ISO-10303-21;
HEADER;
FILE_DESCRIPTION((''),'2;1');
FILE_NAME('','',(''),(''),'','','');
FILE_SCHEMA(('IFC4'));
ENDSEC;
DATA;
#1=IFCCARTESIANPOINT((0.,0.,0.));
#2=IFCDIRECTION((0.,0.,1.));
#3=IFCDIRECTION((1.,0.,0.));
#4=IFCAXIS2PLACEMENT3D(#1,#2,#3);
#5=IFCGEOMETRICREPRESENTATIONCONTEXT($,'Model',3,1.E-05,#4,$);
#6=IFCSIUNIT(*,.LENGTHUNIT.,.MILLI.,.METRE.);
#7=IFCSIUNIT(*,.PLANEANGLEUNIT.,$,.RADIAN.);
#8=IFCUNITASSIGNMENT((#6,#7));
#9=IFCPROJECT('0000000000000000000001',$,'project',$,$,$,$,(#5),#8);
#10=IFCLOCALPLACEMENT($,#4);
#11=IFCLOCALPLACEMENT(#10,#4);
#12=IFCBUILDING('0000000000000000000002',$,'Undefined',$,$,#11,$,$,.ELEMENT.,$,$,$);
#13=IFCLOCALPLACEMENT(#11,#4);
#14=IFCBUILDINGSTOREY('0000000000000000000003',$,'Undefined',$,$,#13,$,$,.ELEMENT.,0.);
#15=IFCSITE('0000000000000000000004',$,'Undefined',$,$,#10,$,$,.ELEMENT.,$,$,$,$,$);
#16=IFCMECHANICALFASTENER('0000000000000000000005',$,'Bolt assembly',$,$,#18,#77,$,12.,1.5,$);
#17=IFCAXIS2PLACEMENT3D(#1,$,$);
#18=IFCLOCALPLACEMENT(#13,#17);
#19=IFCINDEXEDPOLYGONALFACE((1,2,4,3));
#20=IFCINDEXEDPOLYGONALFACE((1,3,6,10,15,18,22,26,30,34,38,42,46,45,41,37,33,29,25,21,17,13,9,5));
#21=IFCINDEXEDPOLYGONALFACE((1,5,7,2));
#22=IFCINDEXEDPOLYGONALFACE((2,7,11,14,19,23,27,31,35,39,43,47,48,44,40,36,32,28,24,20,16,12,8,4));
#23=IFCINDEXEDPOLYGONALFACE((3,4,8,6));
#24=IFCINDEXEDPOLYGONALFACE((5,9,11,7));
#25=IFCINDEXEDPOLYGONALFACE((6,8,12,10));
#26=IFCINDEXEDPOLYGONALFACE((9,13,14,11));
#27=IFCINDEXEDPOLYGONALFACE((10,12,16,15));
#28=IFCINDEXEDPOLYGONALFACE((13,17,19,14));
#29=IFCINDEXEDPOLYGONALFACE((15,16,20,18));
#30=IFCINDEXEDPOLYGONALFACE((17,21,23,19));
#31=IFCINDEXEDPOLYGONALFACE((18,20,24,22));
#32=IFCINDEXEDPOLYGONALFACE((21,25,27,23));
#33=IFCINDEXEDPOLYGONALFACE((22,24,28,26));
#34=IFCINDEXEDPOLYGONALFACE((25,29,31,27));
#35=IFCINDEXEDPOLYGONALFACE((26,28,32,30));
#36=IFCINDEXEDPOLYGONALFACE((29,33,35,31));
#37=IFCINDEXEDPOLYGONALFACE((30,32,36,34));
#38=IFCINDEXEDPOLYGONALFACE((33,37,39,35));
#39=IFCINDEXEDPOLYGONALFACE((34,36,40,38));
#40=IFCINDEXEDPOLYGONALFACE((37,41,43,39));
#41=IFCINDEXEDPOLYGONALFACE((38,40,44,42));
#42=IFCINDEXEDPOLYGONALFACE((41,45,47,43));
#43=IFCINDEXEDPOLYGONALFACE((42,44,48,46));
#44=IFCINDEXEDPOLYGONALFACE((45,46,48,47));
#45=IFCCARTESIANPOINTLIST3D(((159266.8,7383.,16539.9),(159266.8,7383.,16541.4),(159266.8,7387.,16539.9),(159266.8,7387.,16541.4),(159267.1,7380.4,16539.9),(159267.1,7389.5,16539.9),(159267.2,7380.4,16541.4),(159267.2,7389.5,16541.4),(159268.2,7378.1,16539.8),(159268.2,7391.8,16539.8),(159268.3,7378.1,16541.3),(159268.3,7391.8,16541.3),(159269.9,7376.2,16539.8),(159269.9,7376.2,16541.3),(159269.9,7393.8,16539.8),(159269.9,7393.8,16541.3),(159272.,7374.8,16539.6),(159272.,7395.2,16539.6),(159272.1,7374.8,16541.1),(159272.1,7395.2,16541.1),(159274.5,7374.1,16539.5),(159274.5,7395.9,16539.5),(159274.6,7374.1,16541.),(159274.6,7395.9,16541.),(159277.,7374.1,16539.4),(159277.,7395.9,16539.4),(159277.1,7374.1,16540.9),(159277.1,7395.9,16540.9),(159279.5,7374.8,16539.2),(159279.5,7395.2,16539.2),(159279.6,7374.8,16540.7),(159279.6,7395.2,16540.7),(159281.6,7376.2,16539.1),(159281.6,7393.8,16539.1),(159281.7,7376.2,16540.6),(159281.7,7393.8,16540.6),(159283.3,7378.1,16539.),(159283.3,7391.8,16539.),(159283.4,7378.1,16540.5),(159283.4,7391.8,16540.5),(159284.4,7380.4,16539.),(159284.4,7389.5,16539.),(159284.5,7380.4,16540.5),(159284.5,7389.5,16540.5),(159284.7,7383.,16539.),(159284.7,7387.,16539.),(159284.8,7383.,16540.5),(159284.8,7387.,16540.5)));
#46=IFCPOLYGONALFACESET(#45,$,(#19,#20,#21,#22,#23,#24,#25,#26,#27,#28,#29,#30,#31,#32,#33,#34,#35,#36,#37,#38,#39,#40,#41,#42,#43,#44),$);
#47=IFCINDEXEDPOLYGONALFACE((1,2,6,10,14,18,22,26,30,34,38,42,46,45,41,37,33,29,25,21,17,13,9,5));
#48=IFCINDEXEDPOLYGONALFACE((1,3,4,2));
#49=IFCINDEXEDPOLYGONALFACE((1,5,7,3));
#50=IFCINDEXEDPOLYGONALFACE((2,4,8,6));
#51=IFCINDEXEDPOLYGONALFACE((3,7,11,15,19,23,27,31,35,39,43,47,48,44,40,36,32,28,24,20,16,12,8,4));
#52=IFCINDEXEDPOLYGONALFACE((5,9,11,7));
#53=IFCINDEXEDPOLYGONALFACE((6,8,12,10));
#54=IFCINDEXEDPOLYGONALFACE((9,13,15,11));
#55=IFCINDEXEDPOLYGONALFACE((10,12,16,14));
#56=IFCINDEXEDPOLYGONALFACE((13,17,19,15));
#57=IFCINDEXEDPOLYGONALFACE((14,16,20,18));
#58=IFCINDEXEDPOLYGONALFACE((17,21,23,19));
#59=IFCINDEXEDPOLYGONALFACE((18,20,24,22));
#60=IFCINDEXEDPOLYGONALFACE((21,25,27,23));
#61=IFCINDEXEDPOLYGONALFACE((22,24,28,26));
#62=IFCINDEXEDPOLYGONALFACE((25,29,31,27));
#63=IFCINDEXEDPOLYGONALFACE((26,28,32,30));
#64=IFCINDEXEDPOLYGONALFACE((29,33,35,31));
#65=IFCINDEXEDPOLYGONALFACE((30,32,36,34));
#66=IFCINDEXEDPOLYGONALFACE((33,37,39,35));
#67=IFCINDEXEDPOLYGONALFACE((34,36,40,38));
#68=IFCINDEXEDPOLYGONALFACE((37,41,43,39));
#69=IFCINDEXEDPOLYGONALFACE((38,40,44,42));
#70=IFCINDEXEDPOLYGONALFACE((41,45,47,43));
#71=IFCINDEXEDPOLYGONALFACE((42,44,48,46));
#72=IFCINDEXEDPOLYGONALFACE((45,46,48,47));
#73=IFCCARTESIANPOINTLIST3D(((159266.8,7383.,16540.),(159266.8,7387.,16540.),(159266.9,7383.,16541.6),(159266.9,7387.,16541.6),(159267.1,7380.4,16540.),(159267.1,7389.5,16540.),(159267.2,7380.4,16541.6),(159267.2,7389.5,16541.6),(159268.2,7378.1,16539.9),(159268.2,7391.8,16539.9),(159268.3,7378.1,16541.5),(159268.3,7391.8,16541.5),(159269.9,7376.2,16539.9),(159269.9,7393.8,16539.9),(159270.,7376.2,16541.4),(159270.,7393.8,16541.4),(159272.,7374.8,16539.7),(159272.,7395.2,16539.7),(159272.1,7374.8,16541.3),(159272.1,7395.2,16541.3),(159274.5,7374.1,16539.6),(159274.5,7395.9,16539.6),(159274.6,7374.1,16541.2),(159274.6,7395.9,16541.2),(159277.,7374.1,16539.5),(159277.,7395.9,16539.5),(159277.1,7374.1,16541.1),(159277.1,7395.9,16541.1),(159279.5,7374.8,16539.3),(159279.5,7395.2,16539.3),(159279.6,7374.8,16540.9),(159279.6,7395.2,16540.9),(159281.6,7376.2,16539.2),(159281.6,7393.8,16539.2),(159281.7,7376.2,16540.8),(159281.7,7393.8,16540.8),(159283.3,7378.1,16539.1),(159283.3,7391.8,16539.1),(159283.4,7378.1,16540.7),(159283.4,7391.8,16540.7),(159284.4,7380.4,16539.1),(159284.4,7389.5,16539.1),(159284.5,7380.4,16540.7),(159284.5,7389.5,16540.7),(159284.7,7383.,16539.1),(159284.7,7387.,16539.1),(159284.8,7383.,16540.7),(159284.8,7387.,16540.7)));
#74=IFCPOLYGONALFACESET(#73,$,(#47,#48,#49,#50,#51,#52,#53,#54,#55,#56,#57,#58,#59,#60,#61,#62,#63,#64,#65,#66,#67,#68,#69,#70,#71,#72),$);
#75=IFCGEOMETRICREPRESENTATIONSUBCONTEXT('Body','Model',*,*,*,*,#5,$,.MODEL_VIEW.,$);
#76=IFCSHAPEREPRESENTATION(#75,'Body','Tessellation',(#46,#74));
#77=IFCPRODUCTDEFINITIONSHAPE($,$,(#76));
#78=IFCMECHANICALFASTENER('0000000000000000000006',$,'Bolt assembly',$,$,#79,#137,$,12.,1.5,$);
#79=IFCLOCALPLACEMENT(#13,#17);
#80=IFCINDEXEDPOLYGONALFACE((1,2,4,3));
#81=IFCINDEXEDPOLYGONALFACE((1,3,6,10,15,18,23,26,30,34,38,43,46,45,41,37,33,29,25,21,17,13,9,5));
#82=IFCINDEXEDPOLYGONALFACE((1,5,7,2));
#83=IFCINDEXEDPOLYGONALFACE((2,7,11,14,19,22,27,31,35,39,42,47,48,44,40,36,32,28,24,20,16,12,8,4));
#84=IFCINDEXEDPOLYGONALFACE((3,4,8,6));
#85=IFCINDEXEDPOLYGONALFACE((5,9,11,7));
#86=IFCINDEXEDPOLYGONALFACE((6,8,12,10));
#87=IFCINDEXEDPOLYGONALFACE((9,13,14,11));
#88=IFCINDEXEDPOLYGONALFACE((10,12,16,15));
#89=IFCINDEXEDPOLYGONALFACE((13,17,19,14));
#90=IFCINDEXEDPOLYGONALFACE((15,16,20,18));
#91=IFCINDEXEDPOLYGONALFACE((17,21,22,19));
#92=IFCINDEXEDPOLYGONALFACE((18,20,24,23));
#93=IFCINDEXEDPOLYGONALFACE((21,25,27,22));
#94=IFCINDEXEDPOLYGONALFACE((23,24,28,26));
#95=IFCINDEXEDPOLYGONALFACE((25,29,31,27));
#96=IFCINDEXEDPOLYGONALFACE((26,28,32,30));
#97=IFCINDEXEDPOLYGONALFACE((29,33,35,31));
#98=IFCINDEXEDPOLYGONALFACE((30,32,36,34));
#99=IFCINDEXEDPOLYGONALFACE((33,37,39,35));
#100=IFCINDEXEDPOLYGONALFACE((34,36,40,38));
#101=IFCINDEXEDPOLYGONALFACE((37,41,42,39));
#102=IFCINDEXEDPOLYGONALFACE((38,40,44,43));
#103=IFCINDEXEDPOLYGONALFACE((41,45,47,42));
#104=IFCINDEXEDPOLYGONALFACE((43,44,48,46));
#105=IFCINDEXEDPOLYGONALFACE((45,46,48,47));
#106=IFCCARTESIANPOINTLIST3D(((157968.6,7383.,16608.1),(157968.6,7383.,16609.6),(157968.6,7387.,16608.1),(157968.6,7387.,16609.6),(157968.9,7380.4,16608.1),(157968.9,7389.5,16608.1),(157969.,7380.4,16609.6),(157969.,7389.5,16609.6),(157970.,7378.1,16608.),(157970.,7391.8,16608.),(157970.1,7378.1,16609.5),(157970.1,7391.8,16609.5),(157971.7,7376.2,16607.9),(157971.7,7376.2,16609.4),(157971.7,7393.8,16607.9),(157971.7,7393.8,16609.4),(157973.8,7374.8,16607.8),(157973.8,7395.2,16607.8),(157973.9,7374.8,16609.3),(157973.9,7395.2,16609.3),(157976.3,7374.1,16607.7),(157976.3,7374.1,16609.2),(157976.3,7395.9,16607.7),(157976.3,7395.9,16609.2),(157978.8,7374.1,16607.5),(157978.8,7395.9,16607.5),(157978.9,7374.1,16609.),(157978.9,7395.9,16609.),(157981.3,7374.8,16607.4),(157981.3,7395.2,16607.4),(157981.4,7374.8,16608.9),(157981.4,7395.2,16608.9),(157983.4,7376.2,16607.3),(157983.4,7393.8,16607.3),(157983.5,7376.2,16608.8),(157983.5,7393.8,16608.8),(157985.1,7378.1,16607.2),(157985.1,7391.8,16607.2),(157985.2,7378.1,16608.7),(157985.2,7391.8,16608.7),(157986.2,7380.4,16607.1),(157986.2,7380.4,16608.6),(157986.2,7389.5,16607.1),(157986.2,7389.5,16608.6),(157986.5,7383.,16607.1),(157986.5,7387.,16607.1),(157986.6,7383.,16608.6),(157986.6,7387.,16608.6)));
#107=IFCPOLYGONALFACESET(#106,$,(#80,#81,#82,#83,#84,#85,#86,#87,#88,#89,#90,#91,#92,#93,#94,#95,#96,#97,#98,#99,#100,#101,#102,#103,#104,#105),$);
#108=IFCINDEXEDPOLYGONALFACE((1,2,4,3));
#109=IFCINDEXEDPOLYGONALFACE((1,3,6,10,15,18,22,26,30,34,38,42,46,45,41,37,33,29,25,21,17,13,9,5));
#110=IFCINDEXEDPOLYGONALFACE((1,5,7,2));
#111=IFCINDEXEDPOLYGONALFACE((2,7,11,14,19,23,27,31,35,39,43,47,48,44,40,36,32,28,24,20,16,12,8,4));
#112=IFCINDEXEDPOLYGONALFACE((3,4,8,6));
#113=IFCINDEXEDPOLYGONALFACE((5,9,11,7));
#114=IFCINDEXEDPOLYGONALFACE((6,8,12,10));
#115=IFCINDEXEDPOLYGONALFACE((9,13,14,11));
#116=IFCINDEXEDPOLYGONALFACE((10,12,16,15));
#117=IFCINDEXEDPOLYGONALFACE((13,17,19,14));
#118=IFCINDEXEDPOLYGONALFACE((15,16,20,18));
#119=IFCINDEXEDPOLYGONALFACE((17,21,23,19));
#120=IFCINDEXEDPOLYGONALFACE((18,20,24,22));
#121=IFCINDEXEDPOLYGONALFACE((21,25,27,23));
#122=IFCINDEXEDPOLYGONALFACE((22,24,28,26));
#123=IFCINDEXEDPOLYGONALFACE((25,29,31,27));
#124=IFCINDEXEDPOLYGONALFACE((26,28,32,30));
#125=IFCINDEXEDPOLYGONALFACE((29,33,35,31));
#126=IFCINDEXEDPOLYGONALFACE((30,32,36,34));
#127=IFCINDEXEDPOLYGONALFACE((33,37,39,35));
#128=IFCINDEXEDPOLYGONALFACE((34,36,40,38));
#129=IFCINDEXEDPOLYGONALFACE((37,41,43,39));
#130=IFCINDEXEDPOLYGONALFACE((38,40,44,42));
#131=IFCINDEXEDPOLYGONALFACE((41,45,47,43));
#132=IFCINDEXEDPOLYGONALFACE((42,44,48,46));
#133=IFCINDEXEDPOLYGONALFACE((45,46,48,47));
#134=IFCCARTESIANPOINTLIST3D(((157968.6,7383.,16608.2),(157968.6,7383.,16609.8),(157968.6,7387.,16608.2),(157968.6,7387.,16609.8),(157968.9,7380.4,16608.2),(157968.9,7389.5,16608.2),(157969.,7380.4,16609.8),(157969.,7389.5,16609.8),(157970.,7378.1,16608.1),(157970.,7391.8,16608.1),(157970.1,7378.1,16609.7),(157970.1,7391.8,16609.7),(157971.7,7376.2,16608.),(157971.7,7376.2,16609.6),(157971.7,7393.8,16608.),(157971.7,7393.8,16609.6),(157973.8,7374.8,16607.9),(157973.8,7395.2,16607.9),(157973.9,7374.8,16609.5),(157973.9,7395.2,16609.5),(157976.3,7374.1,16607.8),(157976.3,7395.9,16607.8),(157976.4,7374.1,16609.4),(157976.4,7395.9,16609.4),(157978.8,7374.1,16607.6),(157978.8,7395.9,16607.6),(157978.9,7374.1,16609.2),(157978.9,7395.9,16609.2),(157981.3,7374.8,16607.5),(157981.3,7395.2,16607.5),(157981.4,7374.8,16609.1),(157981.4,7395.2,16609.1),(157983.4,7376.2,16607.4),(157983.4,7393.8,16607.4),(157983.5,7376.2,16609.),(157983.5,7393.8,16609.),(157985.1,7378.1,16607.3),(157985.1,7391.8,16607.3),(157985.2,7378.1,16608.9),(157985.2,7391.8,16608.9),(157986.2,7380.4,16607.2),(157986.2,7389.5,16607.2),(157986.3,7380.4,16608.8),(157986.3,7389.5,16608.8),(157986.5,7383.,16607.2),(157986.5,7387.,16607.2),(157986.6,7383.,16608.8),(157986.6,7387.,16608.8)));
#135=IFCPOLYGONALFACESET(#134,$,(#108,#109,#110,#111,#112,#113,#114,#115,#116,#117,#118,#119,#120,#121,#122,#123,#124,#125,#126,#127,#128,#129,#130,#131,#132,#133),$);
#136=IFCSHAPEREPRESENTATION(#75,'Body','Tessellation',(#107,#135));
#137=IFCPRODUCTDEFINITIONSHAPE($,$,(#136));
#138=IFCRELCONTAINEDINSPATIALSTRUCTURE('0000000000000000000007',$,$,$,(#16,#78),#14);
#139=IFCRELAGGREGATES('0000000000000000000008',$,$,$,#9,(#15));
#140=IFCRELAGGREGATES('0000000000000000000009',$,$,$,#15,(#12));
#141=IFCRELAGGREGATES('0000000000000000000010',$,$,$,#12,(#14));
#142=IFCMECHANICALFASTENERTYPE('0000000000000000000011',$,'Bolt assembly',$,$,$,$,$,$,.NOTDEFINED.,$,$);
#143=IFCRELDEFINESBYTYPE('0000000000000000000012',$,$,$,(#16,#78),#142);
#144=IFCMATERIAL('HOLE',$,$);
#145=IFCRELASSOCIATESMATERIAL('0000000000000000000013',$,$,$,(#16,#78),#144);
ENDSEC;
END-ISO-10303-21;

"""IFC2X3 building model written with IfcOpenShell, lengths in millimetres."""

from ifc_helpers import new_model, entity, si_unit, frame, origin_with_axes, place, context, subcontext, project, spatial, source, transform, mapped, material, type_object, element, save


model = new_model("IFC2X3")

# Units and contexts
model_context = context("Model", 3, precision=1e-05, world=origin_with_axes())
body_context = subcontext(model_context, "Body", "Model", "MODEL_VIEW")
ifc_project = project(units=[si_unit("LENGTHUNIT", "METRE", prefix="MILLI"), si_unit("PLANEANGLEUNIT", "RADIAN")], contexts=[model_context])

# Site, building, storey
site_placement = place(None, origin_with_axes())
site = spatial("IfcSite", under=ifc_project, at=site_placement, Name="Undefined", CompositionType="ELEMENT")
building_placement = place(site_placement, origin_with_axes())
building = spatial("IfcBuilding", under=site, at=building_placement, Name="Undefined", CompositionType="ELEMENT")
storey_placement = place(building_placement, origin_with_axes())
storey = spatial("IfcBuildingStorey", under=building, at=storey_placement, Name="Undefined", CompositionType="ELEMENT", Elevation=0.0)

# Mechanical fasteners
ifc_material_1 = material(Name="HOLE")
mechanical_fastener_type = type_object("IfcMechanicalFastenerType", Name="Bolt assembly")
shared_circle_1 = entity("IfcCircle", entity("IfcAxis2Placement2D", entity("IfcCartesianPoint", [0.0, -2.0]), entity("IfcDirection", [1.0, 0.0])), 9.0)
shared_circle_2 = entity("IfcCircle", entity("IfcAxis2Placement2D", entity("IfcCartesianPoint", [0.0, 2.0]), entity("IfcDirection", [-1.0, 0.0])), 9.0)
shared_composite_curve = entity("IfcCompositeCurve", [entity("IfcCompositeCurveSegment", "CONTINUOUS", True, entity("IfcPolyline", [entity("IfcCartesianPoint", [9.0, 2.0]), entity("IfcCartesianPoint", [9.0, -2.0])])), entity("IfcCompositeCurveSegment", "CONTINUOUS", True, entity("IfcTrimmedCurve", shared_circle_1, [entity("IfcParameterValue", 0.0)], [entity("IfcParameterValue", 3.141593)], False, "PARAMETER")), entity("IfcCompositeCurveSegment", "CONTINUOUS", True, entity("IfcPolyline", [entity("IfcCartesianPoint", [-9.0, -2.0]), entity("IfcCartesianPoint", [-9.0, 2.0])])), entity("IfcCompositeCurveSegment", "DISCONTINUOUS", True, entity("IfcTrimmedCurve", shared_circle_2, [entity("IfcParameterValue", 0.0)], [entity("IfcParameterValue", 3.141593)], False, "PARAMETER"))], False)
shared_shape_1 = source(origin_with_axes(), body_context, "Body", "SweptSolid", [
    entity("IfcExtrudedAreaSolid", entity("IfcArbitraryClosedProfileDef", "AREA", None, shared_composite_curve), entity("IfcAxis2Placement3D", entity("IfcCartesianPoint", [0.0, -0.4, 0.0]), entity("IfcDirection", [0.0, 1.0, 0.0]), entity("IfcDirection", [1.0, 0.0, 0.0])), entity("IfcDirection", [0.0, 0.0, 1.0]), 1.5),
    entity("IfcExtrudedAreaSolid", entity("IfcArbitraryClosedProfileDef", "AREA", None, shared_composite_curve), entity("IfcAxis2Placement3D", entity("IfcCartesianPoint", [0.0, -0.6, 0.0]), entity("IfcDirection", [0.0, 1.0, 0.0]), entity("IfcDirection", [1.0, 0.0, 0.0])), entity("IfcDirection", [0.0, 0.0, 1.0]), 1.6),
])
mechanical_fastener_1_placement = place(storey_placement, frame((159275.8, 7385.0, 16540.5), z_axis=(0.0, 1.0, 0.0), x_axis=(0.998627, 0.0, -0.052392)))
element("IfcMechanicalFastener", 1, at=mechanical_fastener_1_placement, inside=storey, type_object=mechanical_fastener_type, material=ifc_material_1, Name="Bolt assembly", NominalDiameter=12.0, NominalLength=1.5, context=body_context, shape_type="MappedRepresentation", body=[
    mapped(shared_shape_1, transform((0.0, 0.0, 0.0))),
])
shared_shape_2 = source(origin_with_axes(), body_context, "Body", "SweptSolid", [
    entity("IfcExtrudedAreaSolid", entity("IfcArbitraryClosedProfileDef", "AREA", None, shared_composite_curve), entity("IfcAxis2Placement3D", entity("IfcCartesianPoint", [0.0, -0.4, 0.0]), entity("IfcDirection", [0.0, 1.0, 0.0]), entity("IfcDirection", [1.0, 0.0, 0.0])), entity("IfcDirection", [0.0, 0.0, 1.0]), 1.5),
    entity("IfcExtrudedAreaSolid", entity("IfcArbitraryClosedProfileDef", "AREA", None, shared_composite_curve), entity("IfcAxis2Placement3D", entity("IfcCartesianPoint", [0.0, -0.6, 0.0]), entity("IfcDirection", [0.0, 1.0, 0.0]), entity("IfcDirection", [1.0, 0.0, 0.0])), entity("IfcDirection", [0.0, 0.0, 1.0]), 1.6),
])
mechanical_fastener_2_placement = place(storey_placement, frame((157977.6, 7385.0, 16608.7), z_axis=(0.0, 1.0, 0.0), x_axis=(0.998627, 0.0, -0.052392)))
element("IfcMechanicalFastener", 2, at=mechanical_fastener_2_placement, inside=storey, type_object=mechanical_fastener_type, material=ifc_material_1, Name="Bolt assembly", NominalDiameter=12.0, NominalLength=1.5, context=body_context, shape_type="MappedRepresentation", body=[
    mapped(shared_shape_2, transform((0.0, 0.0, 0.0))),
])

save(model, "model.ifc")
